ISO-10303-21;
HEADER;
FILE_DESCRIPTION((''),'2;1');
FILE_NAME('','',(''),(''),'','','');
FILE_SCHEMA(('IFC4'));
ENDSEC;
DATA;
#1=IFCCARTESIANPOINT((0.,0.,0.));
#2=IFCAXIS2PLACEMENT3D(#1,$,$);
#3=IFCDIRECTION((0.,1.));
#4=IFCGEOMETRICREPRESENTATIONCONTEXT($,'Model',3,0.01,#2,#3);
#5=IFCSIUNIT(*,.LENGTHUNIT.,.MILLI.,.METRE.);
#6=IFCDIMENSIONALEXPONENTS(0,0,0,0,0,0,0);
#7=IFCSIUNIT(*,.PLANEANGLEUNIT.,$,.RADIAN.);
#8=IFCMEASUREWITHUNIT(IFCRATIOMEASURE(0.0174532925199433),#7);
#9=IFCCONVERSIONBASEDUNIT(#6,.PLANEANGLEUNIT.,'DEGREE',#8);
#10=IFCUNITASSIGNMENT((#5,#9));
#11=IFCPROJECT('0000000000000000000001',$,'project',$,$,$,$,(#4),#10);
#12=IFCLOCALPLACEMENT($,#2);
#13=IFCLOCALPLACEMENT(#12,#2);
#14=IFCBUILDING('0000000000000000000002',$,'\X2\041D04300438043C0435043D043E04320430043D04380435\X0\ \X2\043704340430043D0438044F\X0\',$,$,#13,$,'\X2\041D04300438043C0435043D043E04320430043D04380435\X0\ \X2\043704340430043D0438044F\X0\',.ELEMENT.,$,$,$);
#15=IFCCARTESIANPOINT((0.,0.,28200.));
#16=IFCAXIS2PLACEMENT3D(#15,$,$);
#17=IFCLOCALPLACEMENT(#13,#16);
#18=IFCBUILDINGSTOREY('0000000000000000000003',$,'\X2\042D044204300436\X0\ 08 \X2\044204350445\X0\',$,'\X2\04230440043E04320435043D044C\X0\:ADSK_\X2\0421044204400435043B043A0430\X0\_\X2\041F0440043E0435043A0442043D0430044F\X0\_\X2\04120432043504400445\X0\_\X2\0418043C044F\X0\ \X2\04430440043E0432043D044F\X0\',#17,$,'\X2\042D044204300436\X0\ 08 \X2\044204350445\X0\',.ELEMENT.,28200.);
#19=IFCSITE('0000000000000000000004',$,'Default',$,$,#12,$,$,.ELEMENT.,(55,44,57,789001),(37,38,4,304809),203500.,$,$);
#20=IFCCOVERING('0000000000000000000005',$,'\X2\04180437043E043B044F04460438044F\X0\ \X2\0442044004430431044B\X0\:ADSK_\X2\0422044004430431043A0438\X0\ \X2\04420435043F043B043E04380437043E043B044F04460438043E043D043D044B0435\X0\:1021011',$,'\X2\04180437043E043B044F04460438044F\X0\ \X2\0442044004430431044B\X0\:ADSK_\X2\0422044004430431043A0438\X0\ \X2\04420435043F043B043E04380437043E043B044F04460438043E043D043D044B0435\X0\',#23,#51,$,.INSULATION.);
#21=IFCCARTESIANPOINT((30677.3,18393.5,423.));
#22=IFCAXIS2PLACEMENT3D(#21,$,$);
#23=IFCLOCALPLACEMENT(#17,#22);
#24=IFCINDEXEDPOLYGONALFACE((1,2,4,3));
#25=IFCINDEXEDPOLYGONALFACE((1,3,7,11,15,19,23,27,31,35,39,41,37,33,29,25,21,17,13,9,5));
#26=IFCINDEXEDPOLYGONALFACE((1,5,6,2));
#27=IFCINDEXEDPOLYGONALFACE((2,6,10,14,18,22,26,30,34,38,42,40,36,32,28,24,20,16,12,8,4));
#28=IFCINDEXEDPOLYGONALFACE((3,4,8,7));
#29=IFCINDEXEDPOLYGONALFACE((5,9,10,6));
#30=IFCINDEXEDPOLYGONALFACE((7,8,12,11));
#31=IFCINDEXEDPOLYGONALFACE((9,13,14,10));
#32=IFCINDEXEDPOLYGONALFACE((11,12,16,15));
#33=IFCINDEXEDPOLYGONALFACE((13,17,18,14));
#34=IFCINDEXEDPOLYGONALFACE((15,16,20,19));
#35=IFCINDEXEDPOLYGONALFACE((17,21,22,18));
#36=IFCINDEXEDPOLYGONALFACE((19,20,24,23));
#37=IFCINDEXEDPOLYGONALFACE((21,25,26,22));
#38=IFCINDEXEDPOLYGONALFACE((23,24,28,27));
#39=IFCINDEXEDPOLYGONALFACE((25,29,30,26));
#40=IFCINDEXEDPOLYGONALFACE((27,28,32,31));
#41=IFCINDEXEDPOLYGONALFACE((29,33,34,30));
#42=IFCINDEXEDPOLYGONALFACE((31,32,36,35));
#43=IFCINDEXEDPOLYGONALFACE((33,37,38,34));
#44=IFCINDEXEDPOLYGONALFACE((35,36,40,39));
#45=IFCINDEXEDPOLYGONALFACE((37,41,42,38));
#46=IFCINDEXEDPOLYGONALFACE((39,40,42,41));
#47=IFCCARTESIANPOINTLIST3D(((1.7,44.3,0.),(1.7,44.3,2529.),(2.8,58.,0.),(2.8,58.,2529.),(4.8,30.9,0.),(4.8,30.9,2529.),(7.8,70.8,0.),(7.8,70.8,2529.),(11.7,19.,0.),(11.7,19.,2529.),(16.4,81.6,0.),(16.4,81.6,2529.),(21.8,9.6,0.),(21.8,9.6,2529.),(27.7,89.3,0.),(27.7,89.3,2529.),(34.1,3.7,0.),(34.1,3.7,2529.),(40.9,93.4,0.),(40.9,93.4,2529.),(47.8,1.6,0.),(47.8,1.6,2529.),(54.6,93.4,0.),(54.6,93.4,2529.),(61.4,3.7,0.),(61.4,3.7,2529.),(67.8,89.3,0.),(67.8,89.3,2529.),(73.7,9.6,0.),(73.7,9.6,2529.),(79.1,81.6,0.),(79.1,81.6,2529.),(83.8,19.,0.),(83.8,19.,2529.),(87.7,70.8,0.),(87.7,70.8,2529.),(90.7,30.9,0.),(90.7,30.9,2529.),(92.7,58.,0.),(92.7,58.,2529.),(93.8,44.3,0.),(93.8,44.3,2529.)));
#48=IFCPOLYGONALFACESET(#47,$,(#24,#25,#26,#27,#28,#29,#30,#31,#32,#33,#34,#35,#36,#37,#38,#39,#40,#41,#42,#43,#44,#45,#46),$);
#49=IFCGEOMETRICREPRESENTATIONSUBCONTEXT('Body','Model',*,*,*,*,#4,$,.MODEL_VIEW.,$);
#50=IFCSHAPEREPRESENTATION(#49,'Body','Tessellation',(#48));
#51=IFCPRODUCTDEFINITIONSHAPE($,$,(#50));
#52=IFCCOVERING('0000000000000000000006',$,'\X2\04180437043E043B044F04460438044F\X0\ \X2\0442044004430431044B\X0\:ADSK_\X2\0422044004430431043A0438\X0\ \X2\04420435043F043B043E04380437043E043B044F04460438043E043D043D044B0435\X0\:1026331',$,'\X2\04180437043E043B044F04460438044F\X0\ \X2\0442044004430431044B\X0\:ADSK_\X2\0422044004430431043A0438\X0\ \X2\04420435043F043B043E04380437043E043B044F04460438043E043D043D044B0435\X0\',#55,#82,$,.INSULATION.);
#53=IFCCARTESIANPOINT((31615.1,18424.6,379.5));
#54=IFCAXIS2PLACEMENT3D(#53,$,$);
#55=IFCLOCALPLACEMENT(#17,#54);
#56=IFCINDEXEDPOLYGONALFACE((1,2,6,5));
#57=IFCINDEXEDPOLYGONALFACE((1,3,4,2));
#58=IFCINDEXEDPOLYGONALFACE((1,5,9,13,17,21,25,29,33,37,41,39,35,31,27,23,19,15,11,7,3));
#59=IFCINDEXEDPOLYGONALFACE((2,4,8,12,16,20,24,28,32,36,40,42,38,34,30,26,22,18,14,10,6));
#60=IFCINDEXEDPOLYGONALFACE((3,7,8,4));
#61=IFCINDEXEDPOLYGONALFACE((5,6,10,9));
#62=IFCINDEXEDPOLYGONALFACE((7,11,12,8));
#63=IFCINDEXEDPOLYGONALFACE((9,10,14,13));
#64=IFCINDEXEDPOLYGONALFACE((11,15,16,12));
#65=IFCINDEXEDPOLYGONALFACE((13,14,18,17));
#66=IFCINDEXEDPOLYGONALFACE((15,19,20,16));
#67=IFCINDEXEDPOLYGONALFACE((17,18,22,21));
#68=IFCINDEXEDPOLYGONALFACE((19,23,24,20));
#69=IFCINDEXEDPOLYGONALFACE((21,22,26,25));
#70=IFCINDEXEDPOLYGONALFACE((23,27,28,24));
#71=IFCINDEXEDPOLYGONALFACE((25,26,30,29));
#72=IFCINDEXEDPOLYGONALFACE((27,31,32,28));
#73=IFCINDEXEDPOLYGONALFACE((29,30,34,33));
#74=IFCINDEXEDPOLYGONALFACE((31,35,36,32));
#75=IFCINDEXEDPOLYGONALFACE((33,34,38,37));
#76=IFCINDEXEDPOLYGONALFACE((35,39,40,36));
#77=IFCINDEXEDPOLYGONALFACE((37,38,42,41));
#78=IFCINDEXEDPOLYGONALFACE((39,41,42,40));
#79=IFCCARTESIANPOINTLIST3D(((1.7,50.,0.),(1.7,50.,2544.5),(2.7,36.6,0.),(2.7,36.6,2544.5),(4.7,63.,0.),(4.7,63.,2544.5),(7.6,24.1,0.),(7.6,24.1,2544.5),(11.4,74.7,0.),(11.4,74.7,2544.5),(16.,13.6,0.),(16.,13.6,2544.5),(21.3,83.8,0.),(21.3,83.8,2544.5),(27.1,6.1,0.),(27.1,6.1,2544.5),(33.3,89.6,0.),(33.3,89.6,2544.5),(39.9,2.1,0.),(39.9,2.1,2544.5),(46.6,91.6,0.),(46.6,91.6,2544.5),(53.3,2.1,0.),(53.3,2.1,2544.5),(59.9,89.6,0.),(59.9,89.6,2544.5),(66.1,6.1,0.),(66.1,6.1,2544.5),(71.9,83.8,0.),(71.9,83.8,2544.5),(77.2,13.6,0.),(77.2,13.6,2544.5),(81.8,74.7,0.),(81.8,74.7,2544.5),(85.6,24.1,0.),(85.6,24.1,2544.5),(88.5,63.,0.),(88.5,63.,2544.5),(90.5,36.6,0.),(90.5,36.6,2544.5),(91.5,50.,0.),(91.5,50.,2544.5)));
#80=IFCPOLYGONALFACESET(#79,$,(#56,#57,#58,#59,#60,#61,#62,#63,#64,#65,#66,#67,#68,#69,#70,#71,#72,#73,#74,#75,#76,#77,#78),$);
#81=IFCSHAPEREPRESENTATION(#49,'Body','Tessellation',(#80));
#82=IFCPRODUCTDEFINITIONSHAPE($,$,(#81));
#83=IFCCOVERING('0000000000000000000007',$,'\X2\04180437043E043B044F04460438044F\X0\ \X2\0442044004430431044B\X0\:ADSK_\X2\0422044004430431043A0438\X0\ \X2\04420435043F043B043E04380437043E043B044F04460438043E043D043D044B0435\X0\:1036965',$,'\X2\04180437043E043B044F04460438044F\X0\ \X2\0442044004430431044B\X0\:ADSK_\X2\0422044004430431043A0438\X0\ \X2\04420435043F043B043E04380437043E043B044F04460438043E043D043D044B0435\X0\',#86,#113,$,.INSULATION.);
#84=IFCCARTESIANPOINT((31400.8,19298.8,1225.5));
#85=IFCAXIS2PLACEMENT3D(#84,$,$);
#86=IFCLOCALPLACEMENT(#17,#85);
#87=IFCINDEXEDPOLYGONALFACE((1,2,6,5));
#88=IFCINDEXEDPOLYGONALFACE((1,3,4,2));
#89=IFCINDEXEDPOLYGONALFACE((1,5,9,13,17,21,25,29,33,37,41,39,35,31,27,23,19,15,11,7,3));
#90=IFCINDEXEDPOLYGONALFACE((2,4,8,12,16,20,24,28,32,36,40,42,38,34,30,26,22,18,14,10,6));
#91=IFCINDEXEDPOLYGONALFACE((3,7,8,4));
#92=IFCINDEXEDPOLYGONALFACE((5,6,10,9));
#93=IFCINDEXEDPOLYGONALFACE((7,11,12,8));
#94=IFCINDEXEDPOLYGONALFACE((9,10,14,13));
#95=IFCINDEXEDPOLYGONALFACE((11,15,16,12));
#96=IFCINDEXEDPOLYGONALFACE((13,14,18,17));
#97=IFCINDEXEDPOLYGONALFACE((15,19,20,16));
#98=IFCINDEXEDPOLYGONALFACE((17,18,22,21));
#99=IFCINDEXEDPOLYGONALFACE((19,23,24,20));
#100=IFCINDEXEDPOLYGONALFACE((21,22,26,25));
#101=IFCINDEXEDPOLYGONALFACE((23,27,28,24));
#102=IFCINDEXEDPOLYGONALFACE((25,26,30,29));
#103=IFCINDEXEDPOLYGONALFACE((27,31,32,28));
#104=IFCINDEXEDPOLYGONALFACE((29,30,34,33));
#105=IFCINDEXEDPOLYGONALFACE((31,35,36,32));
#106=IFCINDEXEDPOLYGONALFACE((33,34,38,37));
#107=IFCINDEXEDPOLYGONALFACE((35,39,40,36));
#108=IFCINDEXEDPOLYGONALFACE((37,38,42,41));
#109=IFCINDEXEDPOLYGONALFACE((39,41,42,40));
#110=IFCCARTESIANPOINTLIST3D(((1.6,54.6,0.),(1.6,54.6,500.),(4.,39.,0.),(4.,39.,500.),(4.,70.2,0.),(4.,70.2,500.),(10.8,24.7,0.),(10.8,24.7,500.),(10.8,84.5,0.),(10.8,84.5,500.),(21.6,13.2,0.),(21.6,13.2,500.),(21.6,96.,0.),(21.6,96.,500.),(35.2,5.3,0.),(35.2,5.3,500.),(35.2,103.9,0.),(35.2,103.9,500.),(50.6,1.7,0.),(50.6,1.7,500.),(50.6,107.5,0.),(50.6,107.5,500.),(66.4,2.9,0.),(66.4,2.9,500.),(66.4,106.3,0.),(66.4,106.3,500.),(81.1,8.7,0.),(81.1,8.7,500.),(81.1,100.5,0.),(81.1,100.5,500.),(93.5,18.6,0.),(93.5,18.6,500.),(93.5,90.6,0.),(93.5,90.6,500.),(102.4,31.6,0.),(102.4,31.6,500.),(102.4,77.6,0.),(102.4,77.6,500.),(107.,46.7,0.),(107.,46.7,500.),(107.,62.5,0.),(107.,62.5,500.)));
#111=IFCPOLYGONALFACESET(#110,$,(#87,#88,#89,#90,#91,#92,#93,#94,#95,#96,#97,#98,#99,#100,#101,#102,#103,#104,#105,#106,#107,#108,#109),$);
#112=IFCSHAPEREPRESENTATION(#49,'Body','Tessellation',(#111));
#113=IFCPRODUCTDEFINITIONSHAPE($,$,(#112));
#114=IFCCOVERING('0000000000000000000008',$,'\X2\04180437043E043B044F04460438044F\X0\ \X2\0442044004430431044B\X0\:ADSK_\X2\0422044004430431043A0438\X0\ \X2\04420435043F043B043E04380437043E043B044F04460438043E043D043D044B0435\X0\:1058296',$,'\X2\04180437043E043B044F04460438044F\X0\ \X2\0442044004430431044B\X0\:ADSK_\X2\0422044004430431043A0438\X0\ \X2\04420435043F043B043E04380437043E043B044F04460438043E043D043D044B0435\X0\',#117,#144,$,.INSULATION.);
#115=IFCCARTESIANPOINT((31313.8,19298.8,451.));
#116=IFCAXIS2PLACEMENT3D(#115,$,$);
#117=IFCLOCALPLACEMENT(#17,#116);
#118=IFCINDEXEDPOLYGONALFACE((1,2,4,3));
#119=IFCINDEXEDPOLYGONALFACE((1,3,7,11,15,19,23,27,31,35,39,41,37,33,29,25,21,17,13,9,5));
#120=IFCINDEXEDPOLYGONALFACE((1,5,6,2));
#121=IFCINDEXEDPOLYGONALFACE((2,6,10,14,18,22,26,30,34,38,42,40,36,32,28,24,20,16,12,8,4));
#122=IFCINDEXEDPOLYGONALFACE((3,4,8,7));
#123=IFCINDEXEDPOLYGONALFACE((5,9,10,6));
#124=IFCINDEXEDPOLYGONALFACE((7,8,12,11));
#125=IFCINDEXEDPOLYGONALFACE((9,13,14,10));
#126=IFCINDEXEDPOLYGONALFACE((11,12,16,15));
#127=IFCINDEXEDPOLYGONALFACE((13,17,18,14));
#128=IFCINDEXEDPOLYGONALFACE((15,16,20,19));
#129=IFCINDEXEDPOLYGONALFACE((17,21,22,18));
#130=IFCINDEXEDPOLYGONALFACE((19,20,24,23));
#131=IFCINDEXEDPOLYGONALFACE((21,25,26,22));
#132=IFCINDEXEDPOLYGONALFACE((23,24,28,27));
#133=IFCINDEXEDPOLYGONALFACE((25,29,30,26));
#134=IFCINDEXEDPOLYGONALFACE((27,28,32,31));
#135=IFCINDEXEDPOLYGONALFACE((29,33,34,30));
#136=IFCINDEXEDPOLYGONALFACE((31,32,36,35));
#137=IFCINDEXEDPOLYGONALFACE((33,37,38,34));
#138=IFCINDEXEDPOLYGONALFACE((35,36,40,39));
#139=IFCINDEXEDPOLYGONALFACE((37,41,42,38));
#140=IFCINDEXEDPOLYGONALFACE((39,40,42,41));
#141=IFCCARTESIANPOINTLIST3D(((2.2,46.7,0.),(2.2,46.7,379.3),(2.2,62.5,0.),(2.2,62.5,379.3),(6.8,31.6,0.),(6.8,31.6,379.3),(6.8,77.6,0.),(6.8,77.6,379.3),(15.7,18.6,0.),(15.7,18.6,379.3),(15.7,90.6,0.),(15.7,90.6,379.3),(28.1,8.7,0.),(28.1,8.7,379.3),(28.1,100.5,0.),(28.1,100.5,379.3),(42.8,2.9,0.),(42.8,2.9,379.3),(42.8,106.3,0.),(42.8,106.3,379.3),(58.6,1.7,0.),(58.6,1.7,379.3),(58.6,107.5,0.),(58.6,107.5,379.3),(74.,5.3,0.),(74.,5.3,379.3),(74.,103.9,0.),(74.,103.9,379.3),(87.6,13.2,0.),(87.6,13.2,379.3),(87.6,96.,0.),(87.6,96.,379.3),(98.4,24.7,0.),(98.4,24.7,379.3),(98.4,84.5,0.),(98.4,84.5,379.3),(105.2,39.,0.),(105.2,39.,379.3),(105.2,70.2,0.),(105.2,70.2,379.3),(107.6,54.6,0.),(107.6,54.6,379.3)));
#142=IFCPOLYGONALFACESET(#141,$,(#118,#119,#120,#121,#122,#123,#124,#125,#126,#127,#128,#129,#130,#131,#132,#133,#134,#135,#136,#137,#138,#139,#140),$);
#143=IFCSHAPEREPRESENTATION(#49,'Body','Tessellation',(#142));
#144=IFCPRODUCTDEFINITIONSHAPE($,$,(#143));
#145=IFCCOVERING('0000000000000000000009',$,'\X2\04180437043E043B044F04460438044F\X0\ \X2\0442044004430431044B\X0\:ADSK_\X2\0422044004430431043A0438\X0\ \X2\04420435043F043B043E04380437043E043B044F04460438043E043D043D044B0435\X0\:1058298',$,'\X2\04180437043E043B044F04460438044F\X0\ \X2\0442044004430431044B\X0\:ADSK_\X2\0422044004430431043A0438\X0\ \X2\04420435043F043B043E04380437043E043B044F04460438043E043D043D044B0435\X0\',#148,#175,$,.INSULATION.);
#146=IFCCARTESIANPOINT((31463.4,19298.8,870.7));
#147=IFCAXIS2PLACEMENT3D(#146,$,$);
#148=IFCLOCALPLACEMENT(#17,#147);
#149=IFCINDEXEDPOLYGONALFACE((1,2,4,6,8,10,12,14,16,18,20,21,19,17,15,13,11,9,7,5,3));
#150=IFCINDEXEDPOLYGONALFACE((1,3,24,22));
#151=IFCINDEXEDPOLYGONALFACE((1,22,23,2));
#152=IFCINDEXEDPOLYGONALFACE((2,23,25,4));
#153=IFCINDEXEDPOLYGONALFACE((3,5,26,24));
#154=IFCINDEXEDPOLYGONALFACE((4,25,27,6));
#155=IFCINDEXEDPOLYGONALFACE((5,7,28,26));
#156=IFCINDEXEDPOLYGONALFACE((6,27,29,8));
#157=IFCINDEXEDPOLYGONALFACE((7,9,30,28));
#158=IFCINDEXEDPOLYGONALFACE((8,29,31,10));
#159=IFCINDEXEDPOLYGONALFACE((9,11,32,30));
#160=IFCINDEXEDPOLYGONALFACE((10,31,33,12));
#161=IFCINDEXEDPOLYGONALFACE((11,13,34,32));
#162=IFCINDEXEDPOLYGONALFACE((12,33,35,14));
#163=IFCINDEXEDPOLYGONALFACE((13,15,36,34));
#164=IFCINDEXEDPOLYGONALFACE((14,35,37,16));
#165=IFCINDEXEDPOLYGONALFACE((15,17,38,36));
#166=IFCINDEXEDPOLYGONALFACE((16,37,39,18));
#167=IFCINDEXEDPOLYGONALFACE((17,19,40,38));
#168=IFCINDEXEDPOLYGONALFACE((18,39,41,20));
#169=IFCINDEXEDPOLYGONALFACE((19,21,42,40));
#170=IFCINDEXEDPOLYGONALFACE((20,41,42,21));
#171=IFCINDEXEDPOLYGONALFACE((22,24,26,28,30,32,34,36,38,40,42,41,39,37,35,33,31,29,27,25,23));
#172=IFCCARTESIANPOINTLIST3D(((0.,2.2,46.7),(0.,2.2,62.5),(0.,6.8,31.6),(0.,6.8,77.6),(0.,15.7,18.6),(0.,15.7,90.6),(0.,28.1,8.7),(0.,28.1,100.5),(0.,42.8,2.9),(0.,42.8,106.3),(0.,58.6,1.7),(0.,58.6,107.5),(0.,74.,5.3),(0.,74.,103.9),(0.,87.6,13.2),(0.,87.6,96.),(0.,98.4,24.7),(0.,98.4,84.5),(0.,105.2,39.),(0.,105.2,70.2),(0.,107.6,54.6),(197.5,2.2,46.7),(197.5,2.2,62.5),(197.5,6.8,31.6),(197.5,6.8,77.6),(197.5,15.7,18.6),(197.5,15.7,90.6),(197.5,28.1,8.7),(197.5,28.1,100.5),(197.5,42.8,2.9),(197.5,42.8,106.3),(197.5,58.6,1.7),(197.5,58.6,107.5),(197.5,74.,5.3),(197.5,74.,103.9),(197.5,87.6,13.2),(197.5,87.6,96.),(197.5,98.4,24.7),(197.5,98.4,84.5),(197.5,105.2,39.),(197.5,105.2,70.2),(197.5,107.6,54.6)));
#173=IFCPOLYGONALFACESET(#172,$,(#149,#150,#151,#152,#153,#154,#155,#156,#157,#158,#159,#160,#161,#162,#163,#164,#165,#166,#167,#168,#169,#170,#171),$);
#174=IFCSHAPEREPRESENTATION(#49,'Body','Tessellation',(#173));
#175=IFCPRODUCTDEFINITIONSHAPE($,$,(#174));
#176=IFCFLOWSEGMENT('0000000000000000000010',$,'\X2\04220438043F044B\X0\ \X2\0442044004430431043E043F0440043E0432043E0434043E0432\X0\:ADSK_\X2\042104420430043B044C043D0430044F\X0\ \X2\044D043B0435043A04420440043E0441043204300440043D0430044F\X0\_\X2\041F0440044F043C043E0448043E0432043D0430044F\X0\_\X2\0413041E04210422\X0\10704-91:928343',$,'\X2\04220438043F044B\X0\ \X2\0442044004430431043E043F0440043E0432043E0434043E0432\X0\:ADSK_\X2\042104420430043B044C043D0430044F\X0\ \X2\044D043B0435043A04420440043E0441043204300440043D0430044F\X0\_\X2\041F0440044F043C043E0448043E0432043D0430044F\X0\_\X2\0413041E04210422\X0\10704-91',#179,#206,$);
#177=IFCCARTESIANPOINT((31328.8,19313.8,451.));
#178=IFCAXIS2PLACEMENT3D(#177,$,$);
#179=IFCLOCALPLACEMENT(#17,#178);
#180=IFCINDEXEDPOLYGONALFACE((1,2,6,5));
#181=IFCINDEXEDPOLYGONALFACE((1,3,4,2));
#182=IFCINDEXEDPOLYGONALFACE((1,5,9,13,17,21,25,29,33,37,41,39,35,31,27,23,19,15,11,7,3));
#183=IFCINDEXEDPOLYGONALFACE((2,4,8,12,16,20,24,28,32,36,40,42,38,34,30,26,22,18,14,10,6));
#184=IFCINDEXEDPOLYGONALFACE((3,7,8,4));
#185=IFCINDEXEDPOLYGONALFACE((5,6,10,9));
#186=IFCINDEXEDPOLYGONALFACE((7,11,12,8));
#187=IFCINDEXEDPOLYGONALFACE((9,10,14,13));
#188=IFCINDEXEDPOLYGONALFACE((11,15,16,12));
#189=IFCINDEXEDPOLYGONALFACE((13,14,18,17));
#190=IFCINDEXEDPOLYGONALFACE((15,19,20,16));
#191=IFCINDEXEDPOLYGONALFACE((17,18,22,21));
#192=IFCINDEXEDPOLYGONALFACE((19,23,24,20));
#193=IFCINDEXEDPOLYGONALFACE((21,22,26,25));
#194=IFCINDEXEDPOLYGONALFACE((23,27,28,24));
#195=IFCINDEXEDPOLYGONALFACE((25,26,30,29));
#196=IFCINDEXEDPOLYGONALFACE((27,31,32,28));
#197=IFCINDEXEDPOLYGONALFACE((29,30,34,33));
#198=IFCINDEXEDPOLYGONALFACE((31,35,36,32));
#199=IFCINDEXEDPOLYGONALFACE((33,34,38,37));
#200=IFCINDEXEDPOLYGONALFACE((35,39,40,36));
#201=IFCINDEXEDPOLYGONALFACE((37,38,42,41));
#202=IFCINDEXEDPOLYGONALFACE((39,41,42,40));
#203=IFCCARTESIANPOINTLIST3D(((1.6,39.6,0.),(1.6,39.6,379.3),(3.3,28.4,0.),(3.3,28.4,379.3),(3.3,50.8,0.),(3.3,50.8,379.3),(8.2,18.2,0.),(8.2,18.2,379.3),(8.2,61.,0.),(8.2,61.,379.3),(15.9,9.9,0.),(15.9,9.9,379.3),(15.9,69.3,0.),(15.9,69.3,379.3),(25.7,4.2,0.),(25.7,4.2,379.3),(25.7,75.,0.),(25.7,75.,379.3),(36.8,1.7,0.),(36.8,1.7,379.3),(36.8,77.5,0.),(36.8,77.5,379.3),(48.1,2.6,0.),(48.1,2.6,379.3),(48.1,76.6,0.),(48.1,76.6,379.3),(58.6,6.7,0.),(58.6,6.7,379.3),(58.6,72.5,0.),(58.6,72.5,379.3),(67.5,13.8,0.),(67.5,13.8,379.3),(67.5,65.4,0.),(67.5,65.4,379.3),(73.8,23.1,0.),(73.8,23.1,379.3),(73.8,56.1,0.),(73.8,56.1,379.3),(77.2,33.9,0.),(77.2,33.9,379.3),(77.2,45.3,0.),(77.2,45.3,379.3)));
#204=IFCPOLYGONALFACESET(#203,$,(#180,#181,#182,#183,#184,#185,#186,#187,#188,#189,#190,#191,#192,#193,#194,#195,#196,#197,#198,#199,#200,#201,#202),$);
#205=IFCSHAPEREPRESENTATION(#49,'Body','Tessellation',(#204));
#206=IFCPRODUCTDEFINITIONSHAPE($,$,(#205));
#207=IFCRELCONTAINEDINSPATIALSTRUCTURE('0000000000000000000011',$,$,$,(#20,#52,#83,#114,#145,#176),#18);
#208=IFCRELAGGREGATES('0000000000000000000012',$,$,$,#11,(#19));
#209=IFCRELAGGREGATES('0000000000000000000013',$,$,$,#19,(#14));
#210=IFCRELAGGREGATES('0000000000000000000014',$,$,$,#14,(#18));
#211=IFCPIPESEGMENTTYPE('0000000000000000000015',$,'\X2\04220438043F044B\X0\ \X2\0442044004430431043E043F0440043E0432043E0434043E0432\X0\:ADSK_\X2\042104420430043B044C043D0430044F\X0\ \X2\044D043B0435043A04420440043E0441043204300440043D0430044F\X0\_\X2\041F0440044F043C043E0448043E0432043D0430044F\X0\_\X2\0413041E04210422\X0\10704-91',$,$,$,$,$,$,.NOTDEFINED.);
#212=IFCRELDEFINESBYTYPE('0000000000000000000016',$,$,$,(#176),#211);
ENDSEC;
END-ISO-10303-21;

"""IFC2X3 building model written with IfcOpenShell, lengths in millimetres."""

from ifc_helpers import new_model, entity, si_unit, converted_unit, direction, frame, origin, origin_2d_with_axis, place, context, subcontext, project, spatial, circle, extrude, type_object, element, save


model = new_model("IFC2X3")

# Units and contexts
model_context = context("Model", 3, precision=0.01, world=origin(), true_north=direction((0.0, 1.0)))
body_context = subcontext(model_context, "Body", "Model", "MODEL_VIEW")
ifc_project = project(units=[si_unit("LENGTHUNIT", "METRE", prefix="MILLI"), converted_unit("PLANEANGLEUNIT", "DEGREE", entity("IfcRatioMeasure", 0.0174532925199433), si_unit("PLANEANGLEUNIT", "RADIAN"), dimensions=[0, 0, 0, 0, 0, 0, 0])], contexts=[model_context])

# Site, building, storey
site_placement = place(None, origin())
site = spatial("IfcSite", under=ifc_project, at=site_placement, Name="Default", CompositionType="ELEMENT", RefLatitude=(55, 44, 57, 789001), RefLongitude=(37, 38, 4, 304809), RefElevation=203500.0)
building_placement = place(site_placement, origin())
building = spatial("IfcBuilding", under=site, at=building_placement, Name="Наименование здания", LongName="Наименование здания", CompositionType="ELEMENT")
storey_placement = place(building_placement, frame((0.0, 0.0, 28200.0)))
storey = spatial("IfcBuildingStorey", under=building, at=storey_placement, Name="Этаж 08 тех", ObjectType="Уровень:ADSK_Стрелка_Проектная_Вверх_Имя уровня", LongName="Этаж 08 тех", CompositionType="ELEMENT", Elevation=28200.0)

# Coverings
covering_1_placement = place(storey_placement, frame((30677.3, 18393.5, 423.0)))
element("IfcCovering", 1, at=covering_1_placement, inside=storey, Name="Изоляция трубы:ADSK_Трубки теплоизоляционные:1021011", ObjectType="Изоляция трубы:ADSK_Трубки теплоизоляционные", PredefinedType="INSULATION", context=body_context, shape_type="SweptSolid", body=[
    extrude(circle(Radius=46.1, at=origin_2d_with_axis()), frame((47.8, 47.8, 0.0), z_axis=(0.0, 0.0, 1.0), x_axis=(0.0, -1.0, 0.0)), (0.0, 0.0, 1.0), 2529.0),
])
covering_2_placement = place(storey_placement, frame((31615.1, 18424.6, 379.5)))
element("IfcCovering", 2, at=covering_2_placement, inside=storey, Name="Изоляция трубы:ADSK_Трубки теплоизоляционные:1026331", ObjectType="Изоляция трубы:ADSK_Трубки теплоизоляционные", PredefinedType="INSULATION", context=body_context, shape_type="SweptSolid", body=[
    extrude(circle(Radius=45.0, at=origin_2d_with_axis()), frame((46.6, 46.6, 0.0), z_axis=(0.0, 0.0, 1.0), x_axis=(0.0, 1.0, 0.0)), (0.0, 0.0, 1.0), 2544.5),
])
covering_3_placement = place(storey_placement, frame((31400.8, 19298.8, 1225.5)))
element("IfcCovering", 3, at=covering_3_placement, inside=storey, Name="Изоляция трубы:ADSK_Трубки теплоизоляционные:1036965", ObjectType="Изоляция трубы:ADSK_Трубки теплоизоляционные", PredefinedType="INSULATION", context=body_context, shape_type="SweptSolid", body=[
    extrude(circle(Radius=53.0, at=origin_2d_with_axis()), frame((54.6, 54.6, 0.0), z_axis=(0.0, 0.0, 1.0), x_axis=(-1.0, 0.0, 0.0)), (0.0, 0.0, 1.0), 500.0),
])
covering_4_placement = place(storey_placement, frame((31313.8, 19298.8, 451.0)))
element("IfcCovering", 4, at=covering_4_placement, inside=storey, Name="Изоляция трубы:ADSK_Трубки теплоизоляционные:1058296", ObjectType="Изоляция трубы:ADSK_Трубки теплоизоляционные", PredefinedType="INSULATION", context=body_context, shape_type="SweptSolid", body=[
    extrude(circle(Radius=53.0, at=origin_2d_with_axis()), frame((54.6, 54.6, 0.0)), (0.0, 0.0, 1.0), 379.3),
])
covering_5_placement = place(storey_placement, frame((31463.4, 19298.8, 870.7)))
element("IfcCovering", 5, at=covering_5_placement, inside=storey, Name="Изоляция трубы:ADSK_Трубки теплоизоляционные:1058298", ObjectType="Изоляция трубы:ADSK_Трубки теплоизоляционные", PredefinedType="INSULATION", context=body_context, shape_type="SweptSolid", body=[
    extrude(circle(Radius=53.0, at=origin_2d_with_axis()), frame((0.0, 54.6, 54.6), z_axis=(1.0, 0.0, 0.0), x_axis=(0.0, 1.0, 0.0)), (0.0, 0.0, 1.0), 197.5),
])

# Flow segment
pipe_segment_type_1 = type_object("IfcPipeSegmentType", Name="Типы трубопроводов:ADSK_Стальная электросварная_Прямошовная_ГОСТ10704-91", PredefinedType="NOTDEFINED")
flow_segment_1_placement = place(storey_placement, frame((31328.8, 19313.8, 451.0)))
element("IfcFlowSegment", 6, at=flow_segment_1_placement, inside=storey, type_object=pipe_segment_type_1, Name="Типы трубопроводов:ADSK_Стальная электросварная_Прямошовная_ГОСТ10704-91:928343", ObjectType="Типы трубопроводов:ADSK_Стальная электросварная_Прямошовная_ГОСТ10704-91", context=body_context, shape_type="SweptSolid", body=[
    extrude(circle(Radius=38.0, at=origin_2d_with_axis()), frame((39.6, 39.6, 0.0), z_axis=(0.0, 0.0, 1.0), x_axis=(-1.0, 0.0, 0.0)), (0.0, 0.0, 1.0), 379.3),
])

save(model, "model.ifc")
